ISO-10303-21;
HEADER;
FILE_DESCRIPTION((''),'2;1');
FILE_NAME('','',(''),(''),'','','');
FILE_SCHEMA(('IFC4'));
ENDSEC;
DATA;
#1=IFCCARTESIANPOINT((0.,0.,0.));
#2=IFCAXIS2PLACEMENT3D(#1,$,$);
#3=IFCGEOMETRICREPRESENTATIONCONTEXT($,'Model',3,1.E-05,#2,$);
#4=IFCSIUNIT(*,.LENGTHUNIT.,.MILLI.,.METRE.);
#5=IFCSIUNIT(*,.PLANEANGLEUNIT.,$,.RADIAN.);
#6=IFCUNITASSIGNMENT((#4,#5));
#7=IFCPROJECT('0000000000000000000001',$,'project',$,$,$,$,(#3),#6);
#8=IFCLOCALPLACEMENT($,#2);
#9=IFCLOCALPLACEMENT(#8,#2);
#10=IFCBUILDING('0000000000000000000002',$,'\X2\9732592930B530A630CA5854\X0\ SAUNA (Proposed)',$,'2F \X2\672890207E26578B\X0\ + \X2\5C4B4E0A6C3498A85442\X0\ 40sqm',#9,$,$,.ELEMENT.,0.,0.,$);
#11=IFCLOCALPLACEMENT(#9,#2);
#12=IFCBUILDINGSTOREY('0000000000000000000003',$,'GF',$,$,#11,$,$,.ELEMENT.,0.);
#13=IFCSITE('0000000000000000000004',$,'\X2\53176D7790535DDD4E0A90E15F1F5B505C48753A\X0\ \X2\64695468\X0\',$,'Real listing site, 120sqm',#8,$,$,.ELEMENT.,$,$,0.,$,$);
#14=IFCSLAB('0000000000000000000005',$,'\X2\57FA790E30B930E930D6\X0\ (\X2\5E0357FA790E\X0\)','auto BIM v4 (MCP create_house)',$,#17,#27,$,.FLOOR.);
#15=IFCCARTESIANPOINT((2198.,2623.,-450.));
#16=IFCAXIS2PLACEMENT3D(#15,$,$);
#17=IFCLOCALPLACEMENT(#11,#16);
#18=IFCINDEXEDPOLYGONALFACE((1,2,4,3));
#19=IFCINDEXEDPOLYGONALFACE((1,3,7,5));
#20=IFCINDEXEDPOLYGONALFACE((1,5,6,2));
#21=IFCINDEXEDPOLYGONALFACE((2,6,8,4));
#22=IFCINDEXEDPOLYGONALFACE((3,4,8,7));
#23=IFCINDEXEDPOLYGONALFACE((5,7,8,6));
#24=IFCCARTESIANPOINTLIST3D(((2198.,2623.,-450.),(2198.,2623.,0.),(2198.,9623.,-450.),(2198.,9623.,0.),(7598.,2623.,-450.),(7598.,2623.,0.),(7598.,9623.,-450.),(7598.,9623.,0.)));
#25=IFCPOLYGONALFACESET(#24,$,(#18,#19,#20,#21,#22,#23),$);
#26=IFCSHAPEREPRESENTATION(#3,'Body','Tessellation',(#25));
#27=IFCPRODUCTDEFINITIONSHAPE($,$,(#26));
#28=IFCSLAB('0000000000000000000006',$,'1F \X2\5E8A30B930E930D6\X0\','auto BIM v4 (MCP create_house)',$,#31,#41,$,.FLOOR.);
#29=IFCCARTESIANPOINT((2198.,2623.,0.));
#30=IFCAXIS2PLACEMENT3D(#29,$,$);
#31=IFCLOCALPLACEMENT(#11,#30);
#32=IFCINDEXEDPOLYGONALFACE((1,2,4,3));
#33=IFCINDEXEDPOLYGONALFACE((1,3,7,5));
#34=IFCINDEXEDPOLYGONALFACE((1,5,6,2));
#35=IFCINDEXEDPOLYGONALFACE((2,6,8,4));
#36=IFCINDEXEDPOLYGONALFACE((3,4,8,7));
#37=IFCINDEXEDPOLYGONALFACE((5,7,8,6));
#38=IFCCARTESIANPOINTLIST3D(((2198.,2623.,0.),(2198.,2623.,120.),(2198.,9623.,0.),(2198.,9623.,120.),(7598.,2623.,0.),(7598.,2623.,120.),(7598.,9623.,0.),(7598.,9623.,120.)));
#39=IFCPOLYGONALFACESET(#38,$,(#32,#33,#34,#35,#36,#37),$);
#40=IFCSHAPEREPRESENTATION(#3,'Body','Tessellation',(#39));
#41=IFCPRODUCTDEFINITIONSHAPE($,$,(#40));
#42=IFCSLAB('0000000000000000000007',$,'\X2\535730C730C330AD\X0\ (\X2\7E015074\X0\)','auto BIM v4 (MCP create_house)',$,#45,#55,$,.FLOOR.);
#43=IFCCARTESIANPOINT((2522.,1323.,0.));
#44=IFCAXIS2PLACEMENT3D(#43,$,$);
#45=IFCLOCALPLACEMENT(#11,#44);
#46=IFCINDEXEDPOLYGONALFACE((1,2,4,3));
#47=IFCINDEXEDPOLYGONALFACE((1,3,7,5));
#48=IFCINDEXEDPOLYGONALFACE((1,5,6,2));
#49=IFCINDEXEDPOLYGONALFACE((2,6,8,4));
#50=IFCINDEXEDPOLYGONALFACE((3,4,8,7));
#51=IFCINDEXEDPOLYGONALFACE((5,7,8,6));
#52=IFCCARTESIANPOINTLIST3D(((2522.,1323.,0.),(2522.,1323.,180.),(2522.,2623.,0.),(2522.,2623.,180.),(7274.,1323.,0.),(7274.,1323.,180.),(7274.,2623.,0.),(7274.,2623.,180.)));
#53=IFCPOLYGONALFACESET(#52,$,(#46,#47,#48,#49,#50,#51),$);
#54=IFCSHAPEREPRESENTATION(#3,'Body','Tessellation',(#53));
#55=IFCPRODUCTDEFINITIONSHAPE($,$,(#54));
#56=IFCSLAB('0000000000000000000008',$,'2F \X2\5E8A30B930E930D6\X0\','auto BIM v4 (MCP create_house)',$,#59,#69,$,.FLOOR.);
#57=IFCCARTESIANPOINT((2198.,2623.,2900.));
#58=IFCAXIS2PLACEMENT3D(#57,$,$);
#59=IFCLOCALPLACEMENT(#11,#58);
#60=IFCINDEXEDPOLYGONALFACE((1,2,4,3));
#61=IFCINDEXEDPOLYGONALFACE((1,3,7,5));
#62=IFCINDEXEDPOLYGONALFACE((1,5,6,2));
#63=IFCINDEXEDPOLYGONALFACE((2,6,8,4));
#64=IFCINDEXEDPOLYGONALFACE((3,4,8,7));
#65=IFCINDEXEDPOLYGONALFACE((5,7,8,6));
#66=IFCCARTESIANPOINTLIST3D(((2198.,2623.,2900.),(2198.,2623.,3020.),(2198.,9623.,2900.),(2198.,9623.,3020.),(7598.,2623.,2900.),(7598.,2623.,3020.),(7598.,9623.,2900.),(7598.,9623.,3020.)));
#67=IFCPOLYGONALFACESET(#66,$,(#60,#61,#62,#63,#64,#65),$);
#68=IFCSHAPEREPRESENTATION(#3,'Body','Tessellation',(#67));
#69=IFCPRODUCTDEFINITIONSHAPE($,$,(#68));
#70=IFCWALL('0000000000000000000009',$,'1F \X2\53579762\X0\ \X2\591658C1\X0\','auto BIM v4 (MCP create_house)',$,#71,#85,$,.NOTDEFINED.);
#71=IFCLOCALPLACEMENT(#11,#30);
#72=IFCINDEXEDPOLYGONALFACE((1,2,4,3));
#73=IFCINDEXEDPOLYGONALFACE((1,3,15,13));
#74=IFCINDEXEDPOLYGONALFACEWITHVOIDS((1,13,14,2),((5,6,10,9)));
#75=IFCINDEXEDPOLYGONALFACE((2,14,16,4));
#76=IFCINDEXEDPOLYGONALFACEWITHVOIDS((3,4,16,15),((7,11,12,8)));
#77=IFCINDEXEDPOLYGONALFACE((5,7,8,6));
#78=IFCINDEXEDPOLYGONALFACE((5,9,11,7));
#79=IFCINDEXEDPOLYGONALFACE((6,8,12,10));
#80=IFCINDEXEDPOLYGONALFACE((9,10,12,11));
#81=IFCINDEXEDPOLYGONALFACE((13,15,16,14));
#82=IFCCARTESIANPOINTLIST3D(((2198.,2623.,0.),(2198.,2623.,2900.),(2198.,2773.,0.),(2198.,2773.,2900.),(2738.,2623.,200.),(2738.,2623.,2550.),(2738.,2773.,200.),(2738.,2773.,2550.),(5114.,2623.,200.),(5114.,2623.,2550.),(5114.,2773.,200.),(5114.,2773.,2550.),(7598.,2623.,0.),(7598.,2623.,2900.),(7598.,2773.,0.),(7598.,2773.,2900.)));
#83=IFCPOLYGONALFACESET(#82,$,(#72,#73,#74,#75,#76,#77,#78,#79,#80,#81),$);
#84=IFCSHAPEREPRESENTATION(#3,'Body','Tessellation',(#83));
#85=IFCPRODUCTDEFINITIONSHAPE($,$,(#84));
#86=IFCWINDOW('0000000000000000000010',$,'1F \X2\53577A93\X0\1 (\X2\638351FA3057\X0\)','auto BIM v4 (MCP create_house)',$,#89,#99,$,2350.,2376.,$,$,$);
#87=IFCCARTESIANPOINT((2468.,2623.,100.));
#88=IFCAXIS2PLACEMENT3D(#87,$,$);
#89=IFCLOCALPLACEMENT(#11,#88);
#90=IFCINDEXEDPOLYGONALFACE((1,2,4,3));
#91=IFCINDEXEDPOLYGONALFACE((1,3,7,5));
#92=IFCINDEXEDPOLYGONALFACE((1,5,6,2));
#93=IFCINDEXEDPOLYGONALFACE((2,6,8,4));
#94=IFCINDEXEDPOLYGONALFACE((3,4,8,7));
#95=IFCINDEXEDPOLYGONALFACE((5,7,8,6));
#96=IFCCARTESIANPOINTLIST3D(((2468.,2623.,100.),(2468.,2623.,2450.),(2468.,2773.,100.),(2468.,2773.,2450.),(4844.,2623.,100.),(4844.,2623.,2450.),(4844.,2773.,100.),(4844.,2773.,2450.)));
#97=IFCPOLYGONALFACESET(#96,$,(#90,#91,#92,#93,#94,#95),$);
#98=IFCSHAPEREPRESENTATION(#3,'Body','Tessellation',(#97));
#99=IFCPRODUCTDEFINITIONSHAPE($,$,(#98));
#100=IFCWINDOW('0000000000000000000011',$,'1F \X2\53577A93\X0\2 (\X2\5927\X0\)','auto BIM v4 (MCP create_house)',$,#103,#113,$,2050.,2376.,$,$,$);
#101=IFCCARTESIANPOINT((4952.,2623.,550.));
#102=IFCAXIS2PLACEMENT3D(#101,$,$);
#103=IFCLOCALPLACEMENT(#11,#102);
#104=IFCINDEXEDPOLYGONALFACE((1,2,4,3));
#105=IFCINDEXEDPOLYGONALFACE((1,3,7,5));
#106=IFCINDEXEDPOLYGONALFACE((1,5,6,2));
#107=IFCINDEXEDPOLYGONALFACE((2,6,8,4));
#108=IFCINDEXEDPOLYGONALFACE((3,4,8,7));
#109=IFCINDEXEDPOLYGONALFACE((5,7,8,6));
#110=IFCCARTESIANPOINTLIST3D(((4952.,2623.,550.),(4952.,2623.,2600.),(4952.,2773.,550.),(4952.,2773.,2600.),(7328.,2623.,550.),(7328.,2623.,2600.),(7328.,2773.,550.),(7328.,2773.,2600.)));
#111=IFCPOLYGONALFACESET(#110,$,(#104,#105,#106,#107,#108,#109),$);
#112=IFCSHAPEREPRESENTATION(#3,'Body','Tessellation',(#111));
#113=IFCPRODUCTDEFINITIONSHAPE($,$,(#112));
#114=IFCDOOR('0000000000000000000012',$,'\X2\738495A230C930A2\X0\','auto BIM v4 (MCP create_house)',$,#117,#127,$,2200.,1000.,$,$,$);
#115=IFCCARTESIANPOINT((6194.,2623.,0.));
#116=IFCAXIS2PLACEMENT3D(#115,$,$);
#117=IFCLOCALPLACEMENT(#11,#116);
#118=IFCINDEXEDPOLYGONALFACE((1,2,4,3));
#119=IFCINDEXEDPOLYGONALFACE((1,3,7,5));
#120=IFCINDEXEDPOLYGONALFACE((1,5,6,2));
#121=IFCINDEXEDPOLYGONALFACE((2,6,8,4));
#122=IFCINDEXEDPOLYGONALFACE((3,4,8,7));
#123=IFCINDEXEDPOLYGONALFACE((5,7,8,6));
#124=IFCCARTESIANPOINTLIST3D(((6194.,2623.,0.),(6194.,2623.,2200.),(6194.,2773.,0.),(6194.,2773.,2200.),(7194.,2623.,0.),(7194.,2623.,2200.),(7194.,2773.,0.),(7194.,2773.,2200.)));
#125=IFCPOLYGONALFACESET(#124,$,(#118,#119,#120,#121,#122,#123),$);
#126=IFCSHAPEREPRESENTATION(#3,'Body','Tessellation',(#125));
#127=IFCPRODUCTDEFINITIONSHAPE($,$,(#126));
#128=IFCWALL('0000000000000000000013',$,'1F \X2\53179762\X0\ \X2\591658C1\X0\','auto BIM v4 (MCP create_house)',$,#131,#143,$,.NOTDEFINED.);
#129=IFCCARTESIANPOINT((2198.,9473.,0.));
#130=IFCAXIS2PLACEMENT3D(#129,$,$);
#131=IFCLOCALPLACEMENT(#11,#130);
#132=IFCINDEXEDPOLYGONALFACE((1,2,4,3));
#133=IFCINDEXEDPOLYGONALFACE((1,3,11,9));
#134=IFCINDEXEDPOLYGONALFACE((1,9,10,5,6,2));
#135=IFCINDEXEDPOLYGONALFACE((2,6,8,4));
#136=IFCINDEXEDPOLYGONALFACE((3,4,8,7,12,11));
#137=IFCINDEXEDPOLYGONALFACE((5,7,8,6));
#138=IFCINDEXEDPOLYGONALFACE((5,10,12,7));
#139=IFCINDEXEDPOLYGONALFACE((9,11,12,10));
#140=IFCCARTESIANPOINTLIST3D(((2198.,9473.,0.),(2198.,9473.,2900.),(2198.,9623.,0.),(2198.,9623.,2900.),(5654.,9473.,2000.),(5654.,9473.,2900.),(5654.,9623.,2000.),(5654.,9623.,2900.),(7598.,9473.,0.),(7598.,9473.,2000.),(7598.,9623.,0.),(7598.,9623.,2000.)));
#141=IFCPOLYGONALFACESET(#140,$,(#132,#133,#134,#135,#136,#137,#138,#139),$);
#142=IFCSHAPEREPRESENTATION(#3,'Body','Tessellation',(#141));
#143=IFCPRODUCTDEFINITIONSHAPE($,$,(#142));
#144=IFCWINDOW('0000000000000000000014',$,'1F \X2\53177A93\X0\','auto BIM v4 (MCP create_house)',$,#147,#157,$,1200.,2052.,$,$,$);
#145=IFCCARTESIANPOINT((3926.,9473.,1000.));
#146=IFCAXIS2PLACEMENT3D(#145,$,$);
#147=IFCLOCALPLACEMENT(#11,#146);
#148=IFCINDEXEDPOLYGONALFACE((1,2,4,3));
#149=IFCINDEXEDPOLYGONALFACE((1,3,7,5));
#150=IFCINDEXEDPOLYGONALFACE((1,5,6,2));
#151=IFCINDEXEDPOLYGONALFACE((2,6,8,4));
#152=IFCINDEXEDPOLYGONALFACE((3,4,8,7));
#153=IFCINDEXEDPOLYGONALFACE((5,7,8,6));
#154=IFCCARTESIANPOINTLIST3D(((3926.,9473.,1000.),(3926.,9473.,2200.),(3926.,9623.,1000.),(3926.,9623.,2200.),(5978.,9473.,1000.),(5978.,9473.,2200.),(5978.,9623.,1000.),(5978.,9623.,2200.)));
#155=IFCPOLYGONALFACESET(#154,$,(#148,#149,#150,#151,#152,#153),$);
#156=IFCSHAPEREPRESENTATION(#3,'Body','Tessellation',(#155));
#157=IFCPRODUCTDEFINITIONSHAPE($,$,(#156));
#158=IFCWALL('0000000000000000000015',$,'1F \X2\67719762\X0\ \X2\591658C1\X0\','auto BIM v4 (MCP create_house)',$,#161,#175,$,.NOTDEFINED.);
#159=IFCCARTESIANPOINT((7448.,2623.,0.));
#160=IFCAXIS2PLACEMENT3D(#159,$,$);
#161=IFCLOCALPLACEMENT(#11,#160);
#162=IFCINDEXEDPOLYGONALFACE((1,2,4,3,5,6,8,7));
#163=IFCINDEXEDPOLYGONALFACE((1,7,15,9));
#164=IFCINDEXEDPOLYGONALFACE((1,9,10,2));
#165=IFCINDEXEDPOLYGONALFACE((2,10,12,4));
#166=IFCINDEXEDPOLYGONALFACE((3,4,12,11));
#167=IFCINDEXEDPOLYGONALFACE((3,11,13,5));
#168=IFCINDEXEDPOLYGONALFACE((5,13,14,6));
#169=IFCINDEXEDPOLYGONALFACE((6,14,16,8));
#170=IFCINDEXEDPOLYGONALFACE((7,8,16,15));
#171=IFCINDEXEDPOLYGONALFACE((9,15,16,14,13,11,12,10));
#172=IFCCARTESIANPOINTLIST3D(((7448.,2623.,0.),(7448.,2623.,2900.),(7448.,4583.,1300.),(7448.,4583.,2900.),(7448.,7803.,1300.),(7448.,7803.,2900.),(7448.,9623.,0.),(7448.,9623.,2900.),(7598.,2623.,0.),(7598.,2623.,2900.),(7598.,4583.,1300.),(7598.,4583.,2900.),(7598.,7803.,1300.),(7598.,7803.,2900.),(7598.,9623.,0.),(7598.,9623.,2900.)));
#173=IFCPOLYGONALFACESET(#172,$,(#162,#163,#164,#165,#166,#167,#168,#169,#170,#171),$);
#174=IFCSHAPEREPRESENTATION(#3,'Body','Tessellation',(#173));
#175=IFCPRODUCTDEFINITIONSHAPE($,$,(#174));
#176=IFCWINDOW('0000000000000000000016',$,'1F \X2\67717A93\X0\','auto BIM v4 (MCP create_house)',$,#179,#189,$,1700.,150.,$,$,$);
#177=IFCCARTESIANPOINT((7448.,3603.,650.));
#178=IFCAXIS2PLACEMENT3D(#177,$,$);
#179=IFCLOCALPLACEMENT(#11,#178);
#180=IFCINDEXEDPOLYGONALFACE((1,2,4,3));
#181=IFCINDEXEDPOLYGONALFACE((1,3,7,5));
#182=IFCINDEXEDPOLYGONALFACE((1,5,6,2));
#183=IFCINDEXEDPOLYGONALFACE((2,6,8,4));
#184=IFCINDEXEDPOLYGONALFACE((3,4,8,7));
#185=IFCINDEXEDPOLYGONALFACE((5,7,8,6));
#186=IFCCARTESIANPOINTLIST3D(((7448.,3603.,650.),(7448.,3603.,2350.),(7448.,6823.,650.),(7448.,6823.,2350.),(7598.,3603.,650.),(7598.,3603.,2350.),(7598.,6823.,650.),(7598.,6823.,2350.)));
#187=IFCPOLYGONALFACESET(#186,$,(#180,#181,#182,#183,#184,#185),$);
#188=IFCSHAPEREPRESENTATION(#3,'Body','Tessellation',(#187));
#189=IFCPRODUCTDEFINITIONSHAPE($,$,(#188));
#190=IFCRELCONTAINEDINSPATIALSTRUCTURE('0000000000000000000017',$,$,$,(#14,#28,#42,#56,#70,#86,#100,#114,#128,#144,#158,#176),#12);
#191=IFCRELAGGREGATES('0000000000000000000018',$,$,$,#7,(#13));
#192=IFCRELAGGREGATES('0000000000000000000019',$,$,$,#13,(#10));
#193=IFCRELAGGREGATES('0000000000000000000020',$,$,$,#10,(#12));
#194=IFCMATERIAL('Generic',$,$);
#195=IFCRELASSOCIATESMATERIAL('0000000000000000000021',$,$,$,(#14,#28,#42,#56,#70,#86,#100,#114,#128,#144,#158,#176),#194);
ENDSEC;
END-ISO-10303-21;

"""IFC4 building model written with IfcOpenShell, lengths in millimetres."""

from ifc_helpers import new_model, si_unit, frame, frame_2d, origin, place, context, project, spatial, rectangle, extrude, material, element, fill, save


model = new_model("IFC4")

# Units and contexts
model_context = context("Model", 3, precision=1e-05, world=origin())
ifc_project = project(units=[si_unit("LENGTHUNIT", "METRE", prefix="MILLI"), si_unit("PLANEANGLEUNIT", "RADIAN")], contexts=[model_context])

# Site, building, storey
site_placement = place(None, origin())
site = spatial("IfcSite", under=ifc_project, at=site_placement, Name="北海道川上郡弟子屈町 摩周", ObjectType="Real listing site, 120sqm", CompositionType="ELEMENT", RefElevation=0.0)
building_placement = place(site_placement, origin())
building = spatial("IfcBuilding", under=site, at=building_placement, Name="露天サウナ塔 SAUNA (Proposed)", ObjectType="2F 木造縦型 + 屋上水風呂 40sqm", CompositionType="ELEMENT", ElevationOfRefHeight=0.0, ElevationOfTerrain=0.0)
storey_placement = place(building_placement, origin())
storey = spatial("IfcBuildingStorey", under=building, at=storey_placement, Name="GF", CompositionType="ELEMENT", Elevation=0.0)

# Slabs
ifc_material = material(Name="Generic")
slab_1_placement = place(storey_placement, frame((2198.0, 2623.0, -450.0)))
element("IfcSlab", 1, at=slab_1_placement, inside=storey, material=ifc_material, Name="基礎スラブ (布基礎)", Description="auto BIM v4 (MCP create_house)", PredefinedType="FLOOR", context=model_context, shape_type="SweptSolid", body=[
    extrude(rectangle(XDim=5400.0, YDim=7000.0, at=frame_2d((2700.0, 3500.0))), frame((2198.0, 2623.0, -450.0)), (0.0, 0.0, 1.0), 450.0),
])
slab_2_placement = place(storey_placement, frame((2198.0, 2623.0, 0.0)))
element("IfcSlab", 2, at=slab_2_placement, inside=storey, material=ifc_material, Name="1F 床スラブ", Description="auto BIM v4 (MCP create_house)", PredefinedType="FLOOR", context=model_context, shape_type="SweptSolid", body=[
    extrude(rectangle(XDim=5400.0, YDim=7000.0, at=frame_2d((2700.0, 3500.0))), frame((2198.0, 2623.0, 0.0)), (0.0, 0.0, 1.0), 120.0),
])
slab_3_placement = place(storey_placement, frame((2522.0, 1323.0, 0.0)))
element("IfcSlab", 3, at=slab_3_placement, inside=storey, material=ifc_material, Name="南デッキ (縁側)", Description="auto BIM v4 (MCP create_house)", PredefinedType="FLOOR", context=model_context, shape_type="SweptSolid", body=[
    extrude(rectangle(XDim=4752.0, YDim=1300.0, at=frame_2d((2376.0, 650.0))), frame((2522.0, 1323.0, 0.0)), (0.0, 0.0, 1.0), 180.0),
])
slab_4_placement = place(storey_placement, frame((2198.0, 2623.0, 2900.0)))
element("IfcSlab", 4, at=slab_4_placement, inside=storey, material=ifc_material, Name="2F 床スラブ", Description="auto BIM v4 (MCP create_house)", PredefinedType="FLOOR", context=model_context, shape_type="SweptSolid", body=[
    extrude(rectangle(XDim=5400.0, YDim=7000.0, at=frame_2d((2700.0, 3500.0))), frame((2198.0, 2623.0, 2900.0)), (0.0, 0.0, 1.0), 120.0),
])

# Wall, openings, windows, door
wall_1_placement = place(storey_placement, frame((2198.0, 2623.0, 0.0)))
wall_1 = element("IfcWall", 5, at=wall_1_placement, inside=storey, material=ifc_material, Name="1F 南面 外壁", Description="auto BIM v4 (MCP create_house)", PredefinedType="NOTDEFINED", context=model_context, shape_type="SweptSolid", body=[
    extrude(rectangle(XDim=5400.0, YDim=150.0, at=frame_2d((2700.0, 75.0))), frame((2198.0, 2623.0, 0.0)), (0.0, 0.0, 1.0), 2900.0),
])
opening_1_placement = place(storey_placement, frame((2468.0, 2623.0, 100.0)))
opening_1 = element("IfcOpeningElement", 6, at=opening_1_placement, cuts=wall_1, PredefinedType="NOTDEFINED", context=model_context, shape_type="SweptSolid", body=[
    extrude(rectangle(XDim=2376.0, YDim=150.0, at=frame_2d((1188.0, 75.0))), frame((2468.0, 2623.0, 100.0)), (0.0, 0.0, 1.0), 2350.0),
])
opening_2_placement = place(storey_placement, frame((4952.0, 2623.0, 550.0)))
opening_2 = element("IfcOpeningElement", 7, at=opening_2_placement, cuts=wall_1, PredefinedType="NOTDEFINED", context=model_context, shape_type="SweptSolid", body=[
    extrude(rectangle(XDim=2376.0, YDim=150.0, at=frame_2d((1188.0, 75.0))), frame((4952.0, 2623.0, 550.0)), (0.0, 0.0, 1.0), 2050.0),
])
opening_3_placement = place(storey_placement, frame((6194.0, 2623.0, 0.0)))
opening_3 = element("IfcOpeningElement", 8, at=opening_3_placement, cuts=wall_1, PredefinedType="NOTDEFINED", context=model_context, shape_type="SweptSolid", body=[
    extrude(rectangle(XDim=1000.0, YDim=150.0, at=frame_2d((500.0, 75.0))), frame((6194.0, 2623.0, 0.0)), (0.0, 0.0, 1.0), 2200.0),
])
window_1_placement = place(storey_placement, frame((2468.0, 2623.0, 100.0)))
window_1 = element("IfcWindow", 9, at=window_1_placement, inside=storey, material=ifc_material, Name="1F 南窓1 (掃出し)", Description="auto BIM v4 (MCP create_house)", OverallHeight=2350.0, OverallWidth=2376.0, context=model_context, shape_type="SweptSolid", body=[
    extrude(rectangle(XDim=2376.0, YDim=150.0, at=frame_2d((1188.0, 75.0))), frame((2468.0, 2623.0, 100.0)), (0.0, 0.0, 1.0), 2350.0),
])
fill(opening_1, window_1)
window_2_placement = place(storey_placement, frame((4952.0, 2623.0, 550.0)))
window_2 = element("IfcWindow", 10, at=window_2_placement, inside=storey, material=ifc_material, Name="1F 南窓2 (大)", Description="auto BIM v4 (MCP create_house)", OverallHeight=2050.0, OverallWidth=2376.0, context=model_context, shape_type="SweptSolid", body=[
    extrude(rectangle(XDim=2376.0, YDim=150.0, at=frame_2d((1188.0, 75.0))), frame((4952.0, 2623.0, 550.0)), (0.0, 0.0, 1.0), 2050.0),
])
fill(opening_2, window_2)
door_1_placement = place(storey_placement, frame((6194.0, 2623.0, 0.0)))
door_1 = element("IfcDoor", 11, at=door_1_placement, inside=storey, material=ifc_material, Name="玄関ドア", Description="auto BIM v4 (MCP create_house)", OverallHeight=2200.0, OverallWidth=1000.0, context=model_context, shape_type="SweptSolid", body=[
    extrude(rectangle(XDim=1000.0, YDim=150.0, at=frame_2d((500.0, 75.0))), frame((6194.0, 2623.0, 0.0)), (0.0, 0.0, 1.0), 2200.0),
])
fill(opening_3, door_1)

# Walls, openings, windows
wall_2_placement = place(storey_placement, frame((2198.0, 9473.0, 0.0)))
wall_2 = element("IfcWall", 12, at=wall_2_placement, inside=storey, material=ifc_material, Name="1F 北面 外壁", Description="auto BIM v4 (MCP create_house)", PredefinedType="NOTDEFINED", context=model_context, shape_type="SweptSolid", body=[
    extrude(rectangle(XDim=5400.0, YDim=150.0, at=frame_2d((2700.0, 75.0))), frame((2198.0, 9473.0, 0.0)), (0.0, 0.0, 1.0), 2900.0),
])
opening_4_placement = place(storey_placement, frame((3926.0, 9473.0, 1000.0)))
opening_4 = element("IfcOpeningElement", 13, at=opening_4_placement, cuts=wall_2, PredefinedType="NOTDEFINED", context=model_context, shape_type="SweptSolid", body=[
    extrude(rectangle(XDim=2052.0, YDim=150.0, at=frame_2d((1026.0, 75.0))), frame((3926.0, 9473.0, 1000.0)), (0.0, 0.0, 1.0), 1200.0),
])
window_3_placement = place(storey_placement, frame((3926.0, 9473.0, 1000.0)))
window_3 = element("IfcWindow", 14, at=window_3_placement, inside=storey, material=ifc_material, Name="1F 北窓", Description="auto BIM v4 (MCP create_house)", OverallHeight=1200.0, OverallWidth=2052.0, context=model_context, shape_type="SweptSolid", body=[
    extrude(rectangle(XDim=2052.0, YDim=150.0, at=frame_2d((1026.0, 75.0))), frame((3926.0, 9473.0, 1000.0)), (0.0, 0.0, 1.0), 1200.0),
])
fill(opening_4, window_3)
wall_3_placement = place(storey_placement, frame((7448.0, 2623.0, 0.0)))
wall_3 = element("IfcWall", 15, at=wall_3_placement, inside=storey, material=ifc_material, Name="1F 東面 外壁", Description="auto BIM v4 (MCP create_house)", PredefinedType="NOTDEFINED", context=model_context, shape_type="SweptSolid", body=[
    extrude(rectangle(XDim=150.0, YDim=7000.0, at=frame_2d((75.0, 3500.0))), frame((7448.0, 2623.0, 0.0)), (0.0, 0.0, 1.0), 2900.0),
])
opening_5_placement = place(storey_placement, frame((7448.0, 3603.0, 650.0)))
opening_5 = element("IfcOpeningElement", 16, at=opening_5_placement, cuts=wall_3, PredefinedType="NOTDEFINED", context=model_context, shape_type="SweptSolid", body=[
    extrude(rectangle(XDim=150.0, YDim=3220.0, at=frame_2d((75.0, 1610.0))), frame((7448.0, 3603.0, 650.0)), (0.0, 0.0, 1.0), 1700.0),
])
window_4_placement = place(storey_placement, frame((7448.0, 3603.0, 650.0)))
window_4 = element("IfcWindow", 17, at=window_4_placement, inside=storey, material=ifc_material, Name="1F 東窓", Description="auto BIM v4 (MCP create_house)", OverallHeight=1700.0, OverallWidth=150.0, context=model_context, shape_type="SweptSolid", body=[
    extrude(rectangle(XDim=150.0, YDim=3220.0, at=frame_2d((75.0, 1610.0))), frame((7448.0, 3603.0, 650.0)), (0.0, 0.0, 1.0), 1700.0),
])
fill(opening_5, window_4)

save(model, "model.ifc")
